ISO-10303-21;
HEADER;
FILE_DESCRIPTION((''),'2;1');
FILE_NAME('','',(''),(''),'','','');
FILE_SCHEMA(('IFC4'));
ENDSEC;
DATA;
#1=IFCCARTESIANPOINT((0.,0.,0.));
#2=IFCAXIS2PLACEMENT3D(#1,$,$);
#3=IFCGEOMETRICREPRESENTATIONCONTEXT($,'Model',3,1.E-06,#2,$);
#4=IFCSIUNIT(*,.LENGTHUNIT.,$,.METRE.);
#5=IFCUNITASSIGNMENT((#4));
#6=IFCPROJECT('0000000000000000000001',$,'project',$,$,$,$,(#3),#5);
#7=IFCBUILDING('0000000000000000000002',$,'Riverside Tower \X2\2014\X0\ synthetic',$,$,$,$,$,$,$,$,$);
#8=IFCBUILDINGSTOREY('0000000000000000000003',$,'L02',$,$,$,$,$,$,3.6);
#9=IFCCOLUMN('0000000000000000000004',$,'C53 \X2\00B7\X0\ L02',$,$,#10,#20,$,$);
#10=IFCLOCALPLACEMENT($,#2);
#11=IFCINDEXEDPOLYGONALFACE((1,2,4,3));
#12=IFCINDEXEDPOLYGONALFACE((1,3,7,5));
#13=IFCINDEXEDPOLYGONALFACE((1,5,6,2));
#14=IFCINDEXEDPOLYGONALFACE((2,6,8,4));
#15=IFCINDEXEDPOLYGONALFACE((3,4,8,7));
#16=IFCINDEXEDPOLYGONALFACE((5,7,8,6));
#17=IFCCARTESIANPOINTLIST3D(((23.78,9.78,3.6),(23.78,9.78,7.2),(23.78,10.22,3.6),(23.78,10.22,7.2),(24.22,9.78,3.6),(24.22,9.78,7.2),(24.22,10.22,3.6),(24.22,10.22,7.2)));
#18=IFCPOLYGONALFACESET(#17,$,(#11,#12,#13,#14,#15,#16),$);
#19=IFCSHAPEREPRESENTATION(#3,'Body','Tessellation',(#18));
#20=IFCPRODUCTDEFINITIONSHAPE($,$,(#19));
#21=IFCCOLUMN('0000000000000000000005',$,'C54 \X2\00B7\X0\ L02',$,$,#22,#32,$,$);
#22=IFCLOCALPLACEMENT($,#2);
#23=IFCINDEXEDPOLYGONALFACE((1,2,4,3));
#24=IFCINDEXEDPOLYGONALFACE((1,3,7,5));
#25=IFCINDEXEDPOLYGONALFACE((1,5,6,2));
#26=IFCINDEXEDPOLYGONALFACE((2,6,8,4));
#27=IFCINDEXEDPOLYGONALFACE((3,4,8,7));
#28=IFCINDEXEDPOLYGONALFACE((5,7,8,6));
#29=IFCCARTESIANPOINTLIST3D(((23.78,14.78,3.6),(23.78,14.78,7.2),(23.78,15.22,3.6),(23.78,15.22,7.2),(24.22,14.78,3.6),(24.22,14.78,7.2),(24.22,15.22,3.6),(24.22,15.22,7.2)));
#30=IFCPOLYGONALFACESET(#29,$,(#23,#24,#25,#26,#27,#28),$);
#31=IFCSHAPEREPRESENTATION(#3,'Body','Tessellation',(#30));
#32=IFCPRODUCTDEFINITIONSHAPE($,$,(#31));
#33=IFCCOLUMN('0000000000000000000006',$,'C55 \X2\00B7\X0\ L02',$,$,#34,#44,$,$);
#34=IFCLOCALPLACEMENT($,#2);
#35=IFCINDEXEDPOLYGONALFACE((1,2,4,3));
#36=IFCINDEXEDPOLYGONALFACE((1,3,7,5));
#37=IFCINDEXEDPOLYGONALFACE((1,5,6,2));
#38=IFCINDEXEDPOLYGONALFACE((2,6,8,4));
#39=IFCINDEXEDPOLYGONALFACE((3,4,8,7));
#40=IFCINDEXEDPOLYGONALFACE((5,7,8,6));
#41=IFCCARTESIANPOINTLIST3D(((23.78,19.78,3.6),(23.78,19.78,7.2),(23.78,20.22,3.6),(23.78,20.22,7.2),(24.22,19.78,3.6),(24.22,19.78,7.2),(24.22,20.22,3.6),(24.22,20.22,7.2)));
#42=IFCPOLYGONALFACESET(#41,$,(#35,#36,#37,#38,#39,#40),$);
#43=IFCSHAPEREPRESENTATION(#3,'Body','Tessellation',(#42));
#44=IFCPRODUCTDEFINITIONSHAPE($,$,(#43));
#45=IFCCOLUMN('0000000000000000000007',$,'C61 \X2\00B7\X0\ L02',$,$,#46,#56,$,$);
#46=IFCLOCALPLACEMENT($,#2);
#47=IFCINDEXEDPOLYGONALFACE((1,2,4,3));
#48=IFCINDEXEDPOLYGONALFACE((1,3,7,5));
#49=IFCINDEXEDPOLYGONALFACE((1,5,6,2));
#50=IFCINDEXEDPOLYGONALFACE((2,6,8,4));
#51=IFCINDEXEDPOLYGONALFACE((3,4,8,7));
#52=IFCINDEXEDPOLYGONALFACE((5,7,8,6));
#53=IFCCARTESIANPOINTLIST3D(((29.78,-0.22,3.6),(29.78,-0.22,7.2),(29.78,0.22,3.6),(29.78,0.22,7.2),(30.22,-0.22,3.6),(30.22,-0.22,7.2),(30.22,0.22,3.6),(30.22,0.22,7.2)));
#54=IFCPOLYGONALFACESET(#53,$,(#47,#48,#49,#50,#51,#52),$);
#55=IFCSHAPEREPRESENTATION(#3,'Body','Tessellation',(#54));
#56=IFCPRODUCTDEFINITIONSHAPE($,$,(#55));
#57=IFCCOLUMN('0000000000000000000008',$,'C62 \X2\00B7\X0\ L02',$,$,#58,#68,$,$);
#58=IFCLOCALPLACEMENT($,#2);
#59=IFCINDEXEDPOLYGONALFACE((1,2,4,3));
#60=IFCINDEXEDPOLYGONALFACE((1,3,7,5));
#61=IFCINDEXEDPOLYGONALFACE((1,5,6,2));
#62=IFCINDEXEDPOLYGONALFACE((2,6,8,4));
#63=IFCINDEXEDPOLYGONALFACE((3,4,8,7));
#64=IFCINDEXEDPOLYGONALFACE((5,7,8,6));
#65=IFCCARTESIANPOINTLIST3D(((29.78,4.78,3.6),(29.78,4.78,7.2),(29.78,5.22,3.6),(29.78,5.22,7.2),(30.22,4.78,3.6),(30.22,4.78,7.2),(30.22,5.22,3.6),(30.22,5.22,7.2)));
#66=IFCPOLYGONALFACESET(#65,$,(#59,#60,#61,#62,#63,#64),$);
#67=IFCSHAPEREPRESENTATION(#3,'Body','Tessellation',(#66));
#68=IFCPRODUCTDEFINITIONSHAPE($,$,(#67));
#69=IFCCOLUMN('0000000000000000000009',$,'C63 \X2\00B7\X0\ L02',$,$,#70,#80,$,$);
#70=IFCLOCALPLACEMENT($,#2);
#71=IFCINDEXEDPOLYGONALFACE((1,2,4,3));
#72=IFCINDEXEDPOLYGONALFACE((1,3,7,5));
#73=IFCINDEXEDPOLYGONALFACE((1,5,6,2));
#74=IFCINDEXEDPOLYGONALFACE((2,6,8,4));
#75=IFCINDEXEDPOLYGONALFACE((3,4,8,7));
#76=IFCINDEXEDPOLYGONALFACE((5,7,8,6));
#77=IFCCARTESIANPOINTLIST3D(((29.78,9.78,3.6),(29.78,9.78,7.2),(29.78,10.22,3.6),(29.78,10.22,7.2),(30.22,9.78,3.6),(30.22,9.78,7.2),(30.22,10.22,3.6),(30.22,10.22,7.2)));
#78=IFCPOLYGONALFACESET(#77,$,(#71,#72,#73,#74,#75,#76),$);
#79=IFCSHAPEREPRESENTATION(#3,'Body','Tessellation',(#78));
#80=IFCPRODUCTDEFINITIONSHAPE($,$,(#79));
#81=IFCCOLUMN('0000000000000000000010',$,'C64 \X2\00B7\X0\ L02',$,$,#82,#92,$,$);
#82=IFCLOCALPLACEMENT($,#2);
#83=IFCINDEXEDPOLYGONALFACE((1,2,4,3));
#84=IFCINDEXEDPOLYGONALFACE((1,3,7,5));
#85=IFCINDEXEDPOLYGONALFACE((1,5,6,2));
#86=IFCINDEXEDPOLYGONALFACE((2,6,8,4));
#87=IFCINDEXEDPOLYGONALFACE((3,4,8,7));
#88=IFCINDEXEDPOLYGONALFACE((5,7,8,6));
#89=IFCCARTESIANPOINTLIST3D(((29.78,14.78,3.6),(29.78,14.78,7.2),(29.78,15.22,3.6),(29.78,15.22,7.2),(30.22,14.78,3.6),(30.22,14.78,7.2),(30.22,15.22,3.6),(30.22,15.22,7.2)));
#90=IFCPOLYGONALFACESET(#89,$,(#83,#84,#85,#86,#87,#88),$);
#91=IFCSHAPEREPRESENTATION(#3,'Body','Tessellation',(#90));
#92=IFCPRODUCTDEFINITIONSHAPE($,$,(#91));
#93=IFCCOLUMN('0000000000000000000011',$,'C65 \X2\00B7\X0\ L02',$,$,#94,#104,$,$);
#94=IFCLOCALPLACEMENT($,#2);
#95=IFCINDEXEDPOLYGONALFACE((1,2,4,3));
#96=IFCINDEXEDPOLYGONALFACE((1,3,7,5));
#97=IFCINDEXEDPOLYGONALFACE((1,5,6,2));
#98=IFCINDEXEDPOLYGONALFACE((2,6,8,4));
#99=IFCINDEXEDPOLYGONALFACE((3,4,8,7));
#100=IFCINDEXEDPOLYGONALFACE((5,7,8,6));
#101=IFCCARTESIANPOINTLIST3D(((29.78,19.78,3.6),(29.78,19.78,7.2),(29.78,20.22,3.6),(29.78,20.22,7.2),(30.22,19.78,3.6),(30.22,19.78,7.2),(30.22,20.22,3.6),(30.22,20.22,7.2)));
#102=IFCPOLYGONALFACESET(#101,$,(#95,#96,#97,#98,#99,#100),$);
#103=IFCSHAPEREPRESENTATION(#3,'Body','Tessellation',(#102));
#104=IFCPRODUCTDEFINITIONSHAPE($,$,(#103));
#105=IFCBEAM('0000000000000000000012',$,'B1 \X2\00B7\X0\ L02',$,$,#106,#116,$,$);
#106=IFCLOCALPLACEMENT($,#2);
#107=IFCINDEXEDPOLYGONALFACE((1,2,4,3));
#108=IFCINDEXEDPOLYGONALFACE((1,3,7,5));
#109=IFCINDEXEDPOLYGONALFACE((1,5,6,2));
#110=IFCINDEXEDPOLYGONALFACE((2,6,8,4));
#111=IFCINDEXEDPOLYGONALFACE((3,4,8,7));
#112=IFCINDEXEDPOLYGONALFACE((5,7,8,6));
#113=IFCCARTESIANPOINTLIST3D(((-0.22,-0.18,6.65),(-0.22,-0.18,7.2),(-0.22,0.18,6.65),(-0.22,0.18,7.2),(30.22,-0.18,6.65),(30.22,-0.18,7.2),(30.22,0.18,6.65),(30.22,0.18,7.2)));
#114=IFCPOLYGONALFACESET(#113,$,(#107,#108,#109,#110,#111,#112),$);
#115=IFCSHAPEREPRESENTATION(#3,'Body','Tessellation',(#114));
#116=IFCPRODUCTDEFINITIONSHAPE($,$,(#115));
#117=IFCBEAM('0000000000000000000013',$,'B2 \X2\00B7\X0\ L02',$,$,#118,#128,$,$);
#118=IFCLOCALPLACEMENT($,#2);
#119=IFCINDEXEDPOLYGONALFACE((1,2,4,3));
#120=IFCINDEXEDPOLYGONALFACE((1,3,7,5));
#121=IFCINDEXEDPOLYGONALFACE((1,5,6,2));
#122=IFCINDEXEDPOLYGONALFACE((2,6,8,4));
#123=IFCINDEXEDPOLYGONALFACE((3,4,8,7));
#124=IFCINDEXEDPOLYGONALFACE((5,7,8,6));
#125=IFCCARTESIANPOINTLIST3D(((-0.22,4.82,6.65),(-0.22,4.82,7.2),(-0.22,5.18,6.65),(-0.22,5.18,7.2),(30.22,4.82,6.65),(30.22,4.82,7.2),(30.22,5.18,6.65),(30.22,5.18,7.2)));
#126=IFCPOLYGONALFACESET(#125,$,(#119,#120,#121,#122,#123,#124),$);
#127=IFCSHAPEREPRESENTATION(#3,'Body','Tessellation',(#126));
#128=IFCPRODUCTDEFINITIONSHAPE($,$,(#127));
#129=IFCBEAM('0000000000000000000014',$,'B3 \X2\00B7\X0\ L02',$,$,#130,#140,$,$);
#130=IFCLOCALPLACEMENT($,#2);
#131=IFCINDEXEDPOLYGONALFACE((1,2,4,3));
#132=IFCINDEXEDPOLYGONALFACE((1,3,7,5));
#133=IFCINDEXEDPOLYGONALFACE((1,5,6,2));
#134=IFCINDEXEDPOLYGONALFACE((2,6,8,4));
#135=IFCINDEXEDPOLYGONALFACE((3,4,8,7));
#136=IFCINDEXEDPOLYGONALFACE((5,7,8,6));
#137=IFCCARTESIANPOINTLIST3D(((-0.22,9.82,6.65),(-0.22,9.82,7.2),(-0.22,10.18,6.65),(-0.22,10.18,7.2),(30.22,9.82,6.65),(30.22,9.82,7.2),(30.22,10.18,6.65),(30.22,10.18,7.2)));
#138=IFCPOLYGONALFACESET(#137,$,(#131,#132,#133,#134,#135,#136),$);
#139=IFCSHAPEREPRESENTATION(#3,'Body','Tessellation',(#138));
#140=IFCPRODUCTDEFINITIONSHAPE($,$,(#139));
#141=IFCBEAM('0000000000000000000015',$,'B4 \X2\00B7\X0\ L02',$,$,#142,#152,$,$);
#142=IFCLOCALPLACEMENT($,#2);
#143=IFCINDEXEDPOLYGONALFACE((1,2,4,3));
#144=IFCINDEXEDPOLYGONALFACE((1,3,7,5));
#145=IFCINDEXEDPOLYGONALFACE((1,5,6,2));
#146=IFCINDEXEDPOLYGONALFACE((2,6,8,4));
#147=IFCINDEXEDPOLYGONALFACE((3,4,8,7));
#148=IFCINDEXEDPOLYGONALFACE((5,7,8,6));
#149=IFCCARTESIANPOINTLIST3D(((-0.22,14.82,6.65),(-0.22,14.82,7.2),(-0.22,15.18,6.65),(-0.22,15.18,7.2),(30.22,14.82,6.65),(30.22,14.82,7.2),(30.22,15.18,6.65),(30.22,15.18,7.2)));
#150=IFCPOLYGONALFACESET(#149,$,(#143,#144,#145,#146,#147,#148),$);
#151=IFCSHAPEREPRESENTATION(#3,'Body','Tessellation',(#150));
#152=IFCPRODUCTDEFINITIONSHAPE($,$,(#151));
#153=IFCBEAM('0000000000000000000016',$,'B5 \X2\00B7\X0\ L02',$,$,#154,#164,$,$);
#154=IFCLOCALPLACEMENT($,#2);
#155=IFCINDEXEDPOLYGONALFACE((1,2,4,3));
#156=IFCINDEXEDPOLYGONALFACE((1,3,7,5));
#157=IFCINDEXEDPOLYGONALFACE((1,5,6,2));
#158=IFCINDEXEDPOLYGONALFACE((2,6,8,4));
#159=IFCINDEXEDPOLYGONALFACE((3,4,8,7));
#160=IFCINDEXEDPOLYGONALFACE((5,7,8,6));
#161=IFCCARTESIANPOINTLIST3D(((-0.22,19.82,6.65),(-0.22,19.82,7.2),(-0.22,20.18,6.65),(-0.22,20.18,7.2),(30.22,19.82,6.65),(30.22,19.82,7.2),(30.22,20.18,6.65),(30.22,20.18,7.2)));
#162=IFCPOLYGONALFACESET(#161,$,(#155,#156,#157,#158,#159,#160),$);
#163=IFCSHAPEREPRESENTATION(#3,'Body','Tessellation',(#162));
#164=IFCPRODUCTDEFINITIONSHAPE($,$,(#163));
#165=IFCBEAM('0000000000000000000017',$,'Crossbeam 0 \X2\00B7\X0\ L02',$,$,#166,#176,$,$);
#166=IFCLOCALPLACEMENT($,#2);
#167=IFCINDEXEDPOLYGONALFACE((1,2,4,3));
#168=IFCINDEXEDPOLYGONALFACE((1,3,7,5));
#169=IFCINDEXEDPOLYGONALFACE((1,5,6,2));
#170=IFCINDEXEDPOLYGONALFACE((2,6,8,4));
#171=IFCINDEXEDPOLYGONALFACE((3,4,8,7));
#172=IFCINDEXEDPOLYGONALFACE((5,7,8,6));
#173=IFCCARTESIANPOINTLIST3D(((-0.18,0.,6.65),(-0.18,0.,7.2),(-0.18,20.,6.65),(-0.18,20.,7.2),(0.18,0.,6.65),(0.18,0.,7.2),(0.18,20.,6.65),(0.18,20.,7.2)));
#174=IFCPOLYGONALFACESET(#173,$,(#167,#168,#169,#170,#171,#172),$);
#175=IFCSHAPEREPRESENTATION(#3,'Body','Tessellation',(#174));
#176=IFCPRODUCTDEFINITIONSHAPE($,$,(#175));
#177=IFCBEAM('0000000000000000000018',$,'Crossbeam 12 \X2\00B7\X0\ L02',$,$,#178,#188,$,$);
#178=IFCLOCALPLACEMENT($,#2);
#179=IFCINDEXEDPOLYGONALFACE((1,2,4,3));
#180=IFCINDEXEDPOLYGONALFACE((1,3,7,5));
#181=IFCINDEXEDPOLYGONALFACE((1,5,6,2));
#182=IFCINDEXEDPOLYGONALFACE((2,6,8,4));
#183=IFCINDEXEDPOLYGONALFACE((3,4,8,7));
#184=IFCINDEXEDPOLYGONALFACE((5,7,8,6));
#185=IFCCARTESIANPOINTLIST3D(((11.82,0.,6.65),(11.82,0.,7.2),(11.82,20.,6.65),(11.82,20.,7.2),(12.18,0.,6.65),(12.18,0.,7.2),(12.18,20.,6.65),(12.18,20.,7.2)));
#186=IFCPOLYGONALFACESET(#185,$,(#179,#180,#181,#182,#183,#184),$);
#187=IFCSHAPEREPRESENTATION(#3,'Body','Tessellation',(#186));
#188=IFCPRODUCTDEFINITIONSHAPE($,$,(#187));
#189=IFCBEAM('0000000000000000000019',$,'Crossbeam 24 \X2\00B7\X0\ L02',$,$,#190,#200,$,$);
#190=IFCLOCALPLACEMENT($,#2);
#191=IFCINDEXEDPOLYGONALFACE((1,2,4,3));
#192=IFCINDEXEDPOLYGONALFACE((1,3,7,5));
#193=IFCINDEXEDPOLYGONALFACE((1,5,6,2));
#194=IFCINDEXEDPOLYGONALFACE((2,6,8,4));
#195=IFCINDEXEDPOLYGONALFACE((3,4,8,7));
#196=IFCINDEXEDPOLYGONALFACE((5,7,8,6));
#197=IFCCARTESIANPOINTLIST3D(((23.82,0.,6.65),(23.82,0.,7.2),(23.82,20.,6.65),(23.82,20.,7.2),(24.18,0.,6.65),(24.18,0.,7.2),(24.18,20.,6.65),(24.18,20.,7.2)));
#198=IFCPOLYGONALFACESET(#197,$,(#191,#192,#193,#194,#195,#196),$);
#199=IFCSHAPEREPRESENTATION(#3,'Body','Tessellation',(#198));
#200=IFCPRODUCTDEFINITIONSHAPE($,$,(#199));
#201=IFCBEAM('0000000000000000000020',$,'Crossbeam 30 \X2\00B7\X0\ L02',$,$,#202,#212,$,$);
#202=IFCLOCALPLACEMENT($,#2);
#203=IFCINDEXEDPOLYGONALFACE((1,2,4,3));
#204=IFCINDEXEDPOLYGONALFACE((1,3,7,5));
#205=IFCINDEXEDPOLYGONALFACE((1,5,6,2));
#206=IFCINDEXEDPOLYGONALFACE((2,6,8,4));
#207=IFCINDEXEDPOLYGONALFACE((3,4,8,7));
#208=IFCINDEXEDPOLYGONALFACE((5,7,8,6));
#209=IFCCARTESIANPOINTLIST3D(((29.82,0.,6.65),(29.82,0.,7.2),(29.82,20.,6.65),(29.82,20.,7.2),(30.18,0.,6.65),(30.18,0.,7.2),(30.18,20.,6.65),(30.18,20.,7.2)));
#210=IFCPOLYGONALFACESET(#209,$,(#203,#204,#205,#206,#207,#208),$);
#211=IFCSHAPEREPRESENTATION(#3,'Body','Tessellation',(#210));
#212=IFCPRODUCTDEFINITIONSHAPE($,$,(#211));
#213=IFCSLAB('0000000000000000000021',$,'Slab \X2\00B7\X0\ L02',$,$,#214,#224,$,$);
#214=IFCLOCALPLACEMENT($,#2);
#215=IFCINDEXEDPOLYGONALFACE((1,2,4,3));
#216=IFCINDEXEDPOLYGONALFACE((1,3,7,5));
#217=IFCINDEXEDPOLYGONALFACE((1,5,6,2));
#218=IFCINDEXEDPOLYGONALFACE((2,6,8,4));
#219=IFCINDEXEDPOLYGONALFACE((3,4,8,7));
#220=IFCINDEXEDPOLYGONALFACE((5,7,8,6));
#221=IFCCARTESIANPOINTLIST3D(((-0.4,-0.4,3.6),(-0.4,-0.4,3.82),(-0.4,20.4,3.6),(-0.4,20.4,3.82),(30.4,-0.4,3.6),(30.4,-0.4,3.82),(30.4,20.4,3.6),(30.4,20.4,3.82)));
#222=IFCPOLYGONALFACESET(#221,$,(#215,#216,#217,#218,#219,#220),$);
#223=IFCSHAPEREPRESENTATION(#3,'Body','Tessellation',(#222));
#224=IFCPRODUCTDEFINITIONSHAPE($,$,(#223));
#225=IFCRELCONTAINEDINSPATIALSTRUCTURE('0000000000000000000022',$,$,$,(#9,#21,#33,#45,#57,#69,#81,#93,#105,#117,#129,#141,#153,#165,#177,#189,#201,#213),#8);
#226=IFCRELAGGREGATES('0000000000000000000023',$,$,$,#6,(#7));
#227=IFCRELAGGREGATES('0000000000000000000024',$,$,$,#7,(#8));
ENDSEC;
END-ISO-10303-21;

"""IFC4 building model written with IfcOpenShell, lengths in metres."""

from ifc_helpers import new_model, si_unit, frame, origin, place, context, project, spatial, rectangle, extrude, element, save


model = new_model("IFC4")

# Units and contexts
model_context = context("Model", 3, precision=1e-06, world=origin())
ifc_project = project(units=[si_unit("LENGTHUNIT", "METRE")], contexts=[model_context])

# Building, storey
building = spatial("IfcBuilding", under=ifc_project, Name="Riverside Tower — synthetic")
storey = spatial("IfcBuildingStorey", under=building, Name="L02", Elevation=3.6)

# Columns
for number, where, name in (
    (1, (24.0, 10.0, 3.6), "C53 · L02"),
    (2, (24.0, 15.0, 3.6), "C54 · L02"),
    (3, (24.0, 20.0, 3.6), "C55 · L02"),
    (4, (30.0, 0.0, 3.6), "C61 · L02"),
    (5, (30.0, 5.0, 3.6), "C62 · L02"),
    (6, (30.0, 10.0, 3.6), "C63 · L02"),
    (7, (30.0, 15.0, 3.6), "C64 · L02"),
    (8, (30.0, 20.0, 3.6), "C65 · L02"),
):
    element("IfcColumn", number, at=place(None, frame(where)), inside=storey, Name=name, context=model_context, shape_type="SweptSolid", body=[
        extrude(rectangle(XDim=0.44, YDim=0.44), origin(), (0.0, 0.0, 1.0), 3.6),
    ])

# Beams
for number, where, name in (
    (9, (15.0, 0.0, 6.65), "B1 · L02"),
    (10, (15.0, 5.0, 6.65), "B2 · L02"),
    (11, (15.0, 10.0, 6.65), "B3 · L02"),
    (12, (15.0, 15.0, 6.65), "B4 · L02"),
    (13, (15.0, 20.0, 6.65), "B5 · L02"),
):
    element("IfcBeam", number, at=place(None, frame(where)), inside=storey, Name=name, context=model_context, shape_type="SweptSolid", body=[
        extrude(rectangle(XDim=30.44, YDim=0.36), origin(), (0.0, 0.0, 1.0), 0.55),
    ])
for number, where, name in (
    (14, (0.0, 10.0, 6.65), "Crossbeam 0 · L02"),
    (15, (12.0, 10.0, 6.65), "Crossbeam 12 · L02"),
    (16, (24.0, 10.0, 6.65), "Crossbeam 24 · L02"),
    (17, (30.0, 10.0, 6.65), "Crossbeam 30 · L02"),
):
    element("IfcBeam", number, at=place(None, frame(where)), inside=storey, Name=name, context=model_context, shape_type="SweptSolid", body=[
        extrude(rectangle(XDim=0.36, YDim=20.0), origin(), (0.0, 0.0, 1.0), 0.55),
    ])

# Slab
slab_placement = place(None, frame((15.0, 10.0, 3.6)))
element("IfcSlab", 18, at=slab_placement, inside=storey, Name="Slab · L02", context=model_context, shape_type="SweptSolid", body=[
    extrude(rectangle(XDim=30.8, YDim=20.8), origin(), (0.0, 0.0, 1.0), 0.22),
])

save(model, "model.ifc")
